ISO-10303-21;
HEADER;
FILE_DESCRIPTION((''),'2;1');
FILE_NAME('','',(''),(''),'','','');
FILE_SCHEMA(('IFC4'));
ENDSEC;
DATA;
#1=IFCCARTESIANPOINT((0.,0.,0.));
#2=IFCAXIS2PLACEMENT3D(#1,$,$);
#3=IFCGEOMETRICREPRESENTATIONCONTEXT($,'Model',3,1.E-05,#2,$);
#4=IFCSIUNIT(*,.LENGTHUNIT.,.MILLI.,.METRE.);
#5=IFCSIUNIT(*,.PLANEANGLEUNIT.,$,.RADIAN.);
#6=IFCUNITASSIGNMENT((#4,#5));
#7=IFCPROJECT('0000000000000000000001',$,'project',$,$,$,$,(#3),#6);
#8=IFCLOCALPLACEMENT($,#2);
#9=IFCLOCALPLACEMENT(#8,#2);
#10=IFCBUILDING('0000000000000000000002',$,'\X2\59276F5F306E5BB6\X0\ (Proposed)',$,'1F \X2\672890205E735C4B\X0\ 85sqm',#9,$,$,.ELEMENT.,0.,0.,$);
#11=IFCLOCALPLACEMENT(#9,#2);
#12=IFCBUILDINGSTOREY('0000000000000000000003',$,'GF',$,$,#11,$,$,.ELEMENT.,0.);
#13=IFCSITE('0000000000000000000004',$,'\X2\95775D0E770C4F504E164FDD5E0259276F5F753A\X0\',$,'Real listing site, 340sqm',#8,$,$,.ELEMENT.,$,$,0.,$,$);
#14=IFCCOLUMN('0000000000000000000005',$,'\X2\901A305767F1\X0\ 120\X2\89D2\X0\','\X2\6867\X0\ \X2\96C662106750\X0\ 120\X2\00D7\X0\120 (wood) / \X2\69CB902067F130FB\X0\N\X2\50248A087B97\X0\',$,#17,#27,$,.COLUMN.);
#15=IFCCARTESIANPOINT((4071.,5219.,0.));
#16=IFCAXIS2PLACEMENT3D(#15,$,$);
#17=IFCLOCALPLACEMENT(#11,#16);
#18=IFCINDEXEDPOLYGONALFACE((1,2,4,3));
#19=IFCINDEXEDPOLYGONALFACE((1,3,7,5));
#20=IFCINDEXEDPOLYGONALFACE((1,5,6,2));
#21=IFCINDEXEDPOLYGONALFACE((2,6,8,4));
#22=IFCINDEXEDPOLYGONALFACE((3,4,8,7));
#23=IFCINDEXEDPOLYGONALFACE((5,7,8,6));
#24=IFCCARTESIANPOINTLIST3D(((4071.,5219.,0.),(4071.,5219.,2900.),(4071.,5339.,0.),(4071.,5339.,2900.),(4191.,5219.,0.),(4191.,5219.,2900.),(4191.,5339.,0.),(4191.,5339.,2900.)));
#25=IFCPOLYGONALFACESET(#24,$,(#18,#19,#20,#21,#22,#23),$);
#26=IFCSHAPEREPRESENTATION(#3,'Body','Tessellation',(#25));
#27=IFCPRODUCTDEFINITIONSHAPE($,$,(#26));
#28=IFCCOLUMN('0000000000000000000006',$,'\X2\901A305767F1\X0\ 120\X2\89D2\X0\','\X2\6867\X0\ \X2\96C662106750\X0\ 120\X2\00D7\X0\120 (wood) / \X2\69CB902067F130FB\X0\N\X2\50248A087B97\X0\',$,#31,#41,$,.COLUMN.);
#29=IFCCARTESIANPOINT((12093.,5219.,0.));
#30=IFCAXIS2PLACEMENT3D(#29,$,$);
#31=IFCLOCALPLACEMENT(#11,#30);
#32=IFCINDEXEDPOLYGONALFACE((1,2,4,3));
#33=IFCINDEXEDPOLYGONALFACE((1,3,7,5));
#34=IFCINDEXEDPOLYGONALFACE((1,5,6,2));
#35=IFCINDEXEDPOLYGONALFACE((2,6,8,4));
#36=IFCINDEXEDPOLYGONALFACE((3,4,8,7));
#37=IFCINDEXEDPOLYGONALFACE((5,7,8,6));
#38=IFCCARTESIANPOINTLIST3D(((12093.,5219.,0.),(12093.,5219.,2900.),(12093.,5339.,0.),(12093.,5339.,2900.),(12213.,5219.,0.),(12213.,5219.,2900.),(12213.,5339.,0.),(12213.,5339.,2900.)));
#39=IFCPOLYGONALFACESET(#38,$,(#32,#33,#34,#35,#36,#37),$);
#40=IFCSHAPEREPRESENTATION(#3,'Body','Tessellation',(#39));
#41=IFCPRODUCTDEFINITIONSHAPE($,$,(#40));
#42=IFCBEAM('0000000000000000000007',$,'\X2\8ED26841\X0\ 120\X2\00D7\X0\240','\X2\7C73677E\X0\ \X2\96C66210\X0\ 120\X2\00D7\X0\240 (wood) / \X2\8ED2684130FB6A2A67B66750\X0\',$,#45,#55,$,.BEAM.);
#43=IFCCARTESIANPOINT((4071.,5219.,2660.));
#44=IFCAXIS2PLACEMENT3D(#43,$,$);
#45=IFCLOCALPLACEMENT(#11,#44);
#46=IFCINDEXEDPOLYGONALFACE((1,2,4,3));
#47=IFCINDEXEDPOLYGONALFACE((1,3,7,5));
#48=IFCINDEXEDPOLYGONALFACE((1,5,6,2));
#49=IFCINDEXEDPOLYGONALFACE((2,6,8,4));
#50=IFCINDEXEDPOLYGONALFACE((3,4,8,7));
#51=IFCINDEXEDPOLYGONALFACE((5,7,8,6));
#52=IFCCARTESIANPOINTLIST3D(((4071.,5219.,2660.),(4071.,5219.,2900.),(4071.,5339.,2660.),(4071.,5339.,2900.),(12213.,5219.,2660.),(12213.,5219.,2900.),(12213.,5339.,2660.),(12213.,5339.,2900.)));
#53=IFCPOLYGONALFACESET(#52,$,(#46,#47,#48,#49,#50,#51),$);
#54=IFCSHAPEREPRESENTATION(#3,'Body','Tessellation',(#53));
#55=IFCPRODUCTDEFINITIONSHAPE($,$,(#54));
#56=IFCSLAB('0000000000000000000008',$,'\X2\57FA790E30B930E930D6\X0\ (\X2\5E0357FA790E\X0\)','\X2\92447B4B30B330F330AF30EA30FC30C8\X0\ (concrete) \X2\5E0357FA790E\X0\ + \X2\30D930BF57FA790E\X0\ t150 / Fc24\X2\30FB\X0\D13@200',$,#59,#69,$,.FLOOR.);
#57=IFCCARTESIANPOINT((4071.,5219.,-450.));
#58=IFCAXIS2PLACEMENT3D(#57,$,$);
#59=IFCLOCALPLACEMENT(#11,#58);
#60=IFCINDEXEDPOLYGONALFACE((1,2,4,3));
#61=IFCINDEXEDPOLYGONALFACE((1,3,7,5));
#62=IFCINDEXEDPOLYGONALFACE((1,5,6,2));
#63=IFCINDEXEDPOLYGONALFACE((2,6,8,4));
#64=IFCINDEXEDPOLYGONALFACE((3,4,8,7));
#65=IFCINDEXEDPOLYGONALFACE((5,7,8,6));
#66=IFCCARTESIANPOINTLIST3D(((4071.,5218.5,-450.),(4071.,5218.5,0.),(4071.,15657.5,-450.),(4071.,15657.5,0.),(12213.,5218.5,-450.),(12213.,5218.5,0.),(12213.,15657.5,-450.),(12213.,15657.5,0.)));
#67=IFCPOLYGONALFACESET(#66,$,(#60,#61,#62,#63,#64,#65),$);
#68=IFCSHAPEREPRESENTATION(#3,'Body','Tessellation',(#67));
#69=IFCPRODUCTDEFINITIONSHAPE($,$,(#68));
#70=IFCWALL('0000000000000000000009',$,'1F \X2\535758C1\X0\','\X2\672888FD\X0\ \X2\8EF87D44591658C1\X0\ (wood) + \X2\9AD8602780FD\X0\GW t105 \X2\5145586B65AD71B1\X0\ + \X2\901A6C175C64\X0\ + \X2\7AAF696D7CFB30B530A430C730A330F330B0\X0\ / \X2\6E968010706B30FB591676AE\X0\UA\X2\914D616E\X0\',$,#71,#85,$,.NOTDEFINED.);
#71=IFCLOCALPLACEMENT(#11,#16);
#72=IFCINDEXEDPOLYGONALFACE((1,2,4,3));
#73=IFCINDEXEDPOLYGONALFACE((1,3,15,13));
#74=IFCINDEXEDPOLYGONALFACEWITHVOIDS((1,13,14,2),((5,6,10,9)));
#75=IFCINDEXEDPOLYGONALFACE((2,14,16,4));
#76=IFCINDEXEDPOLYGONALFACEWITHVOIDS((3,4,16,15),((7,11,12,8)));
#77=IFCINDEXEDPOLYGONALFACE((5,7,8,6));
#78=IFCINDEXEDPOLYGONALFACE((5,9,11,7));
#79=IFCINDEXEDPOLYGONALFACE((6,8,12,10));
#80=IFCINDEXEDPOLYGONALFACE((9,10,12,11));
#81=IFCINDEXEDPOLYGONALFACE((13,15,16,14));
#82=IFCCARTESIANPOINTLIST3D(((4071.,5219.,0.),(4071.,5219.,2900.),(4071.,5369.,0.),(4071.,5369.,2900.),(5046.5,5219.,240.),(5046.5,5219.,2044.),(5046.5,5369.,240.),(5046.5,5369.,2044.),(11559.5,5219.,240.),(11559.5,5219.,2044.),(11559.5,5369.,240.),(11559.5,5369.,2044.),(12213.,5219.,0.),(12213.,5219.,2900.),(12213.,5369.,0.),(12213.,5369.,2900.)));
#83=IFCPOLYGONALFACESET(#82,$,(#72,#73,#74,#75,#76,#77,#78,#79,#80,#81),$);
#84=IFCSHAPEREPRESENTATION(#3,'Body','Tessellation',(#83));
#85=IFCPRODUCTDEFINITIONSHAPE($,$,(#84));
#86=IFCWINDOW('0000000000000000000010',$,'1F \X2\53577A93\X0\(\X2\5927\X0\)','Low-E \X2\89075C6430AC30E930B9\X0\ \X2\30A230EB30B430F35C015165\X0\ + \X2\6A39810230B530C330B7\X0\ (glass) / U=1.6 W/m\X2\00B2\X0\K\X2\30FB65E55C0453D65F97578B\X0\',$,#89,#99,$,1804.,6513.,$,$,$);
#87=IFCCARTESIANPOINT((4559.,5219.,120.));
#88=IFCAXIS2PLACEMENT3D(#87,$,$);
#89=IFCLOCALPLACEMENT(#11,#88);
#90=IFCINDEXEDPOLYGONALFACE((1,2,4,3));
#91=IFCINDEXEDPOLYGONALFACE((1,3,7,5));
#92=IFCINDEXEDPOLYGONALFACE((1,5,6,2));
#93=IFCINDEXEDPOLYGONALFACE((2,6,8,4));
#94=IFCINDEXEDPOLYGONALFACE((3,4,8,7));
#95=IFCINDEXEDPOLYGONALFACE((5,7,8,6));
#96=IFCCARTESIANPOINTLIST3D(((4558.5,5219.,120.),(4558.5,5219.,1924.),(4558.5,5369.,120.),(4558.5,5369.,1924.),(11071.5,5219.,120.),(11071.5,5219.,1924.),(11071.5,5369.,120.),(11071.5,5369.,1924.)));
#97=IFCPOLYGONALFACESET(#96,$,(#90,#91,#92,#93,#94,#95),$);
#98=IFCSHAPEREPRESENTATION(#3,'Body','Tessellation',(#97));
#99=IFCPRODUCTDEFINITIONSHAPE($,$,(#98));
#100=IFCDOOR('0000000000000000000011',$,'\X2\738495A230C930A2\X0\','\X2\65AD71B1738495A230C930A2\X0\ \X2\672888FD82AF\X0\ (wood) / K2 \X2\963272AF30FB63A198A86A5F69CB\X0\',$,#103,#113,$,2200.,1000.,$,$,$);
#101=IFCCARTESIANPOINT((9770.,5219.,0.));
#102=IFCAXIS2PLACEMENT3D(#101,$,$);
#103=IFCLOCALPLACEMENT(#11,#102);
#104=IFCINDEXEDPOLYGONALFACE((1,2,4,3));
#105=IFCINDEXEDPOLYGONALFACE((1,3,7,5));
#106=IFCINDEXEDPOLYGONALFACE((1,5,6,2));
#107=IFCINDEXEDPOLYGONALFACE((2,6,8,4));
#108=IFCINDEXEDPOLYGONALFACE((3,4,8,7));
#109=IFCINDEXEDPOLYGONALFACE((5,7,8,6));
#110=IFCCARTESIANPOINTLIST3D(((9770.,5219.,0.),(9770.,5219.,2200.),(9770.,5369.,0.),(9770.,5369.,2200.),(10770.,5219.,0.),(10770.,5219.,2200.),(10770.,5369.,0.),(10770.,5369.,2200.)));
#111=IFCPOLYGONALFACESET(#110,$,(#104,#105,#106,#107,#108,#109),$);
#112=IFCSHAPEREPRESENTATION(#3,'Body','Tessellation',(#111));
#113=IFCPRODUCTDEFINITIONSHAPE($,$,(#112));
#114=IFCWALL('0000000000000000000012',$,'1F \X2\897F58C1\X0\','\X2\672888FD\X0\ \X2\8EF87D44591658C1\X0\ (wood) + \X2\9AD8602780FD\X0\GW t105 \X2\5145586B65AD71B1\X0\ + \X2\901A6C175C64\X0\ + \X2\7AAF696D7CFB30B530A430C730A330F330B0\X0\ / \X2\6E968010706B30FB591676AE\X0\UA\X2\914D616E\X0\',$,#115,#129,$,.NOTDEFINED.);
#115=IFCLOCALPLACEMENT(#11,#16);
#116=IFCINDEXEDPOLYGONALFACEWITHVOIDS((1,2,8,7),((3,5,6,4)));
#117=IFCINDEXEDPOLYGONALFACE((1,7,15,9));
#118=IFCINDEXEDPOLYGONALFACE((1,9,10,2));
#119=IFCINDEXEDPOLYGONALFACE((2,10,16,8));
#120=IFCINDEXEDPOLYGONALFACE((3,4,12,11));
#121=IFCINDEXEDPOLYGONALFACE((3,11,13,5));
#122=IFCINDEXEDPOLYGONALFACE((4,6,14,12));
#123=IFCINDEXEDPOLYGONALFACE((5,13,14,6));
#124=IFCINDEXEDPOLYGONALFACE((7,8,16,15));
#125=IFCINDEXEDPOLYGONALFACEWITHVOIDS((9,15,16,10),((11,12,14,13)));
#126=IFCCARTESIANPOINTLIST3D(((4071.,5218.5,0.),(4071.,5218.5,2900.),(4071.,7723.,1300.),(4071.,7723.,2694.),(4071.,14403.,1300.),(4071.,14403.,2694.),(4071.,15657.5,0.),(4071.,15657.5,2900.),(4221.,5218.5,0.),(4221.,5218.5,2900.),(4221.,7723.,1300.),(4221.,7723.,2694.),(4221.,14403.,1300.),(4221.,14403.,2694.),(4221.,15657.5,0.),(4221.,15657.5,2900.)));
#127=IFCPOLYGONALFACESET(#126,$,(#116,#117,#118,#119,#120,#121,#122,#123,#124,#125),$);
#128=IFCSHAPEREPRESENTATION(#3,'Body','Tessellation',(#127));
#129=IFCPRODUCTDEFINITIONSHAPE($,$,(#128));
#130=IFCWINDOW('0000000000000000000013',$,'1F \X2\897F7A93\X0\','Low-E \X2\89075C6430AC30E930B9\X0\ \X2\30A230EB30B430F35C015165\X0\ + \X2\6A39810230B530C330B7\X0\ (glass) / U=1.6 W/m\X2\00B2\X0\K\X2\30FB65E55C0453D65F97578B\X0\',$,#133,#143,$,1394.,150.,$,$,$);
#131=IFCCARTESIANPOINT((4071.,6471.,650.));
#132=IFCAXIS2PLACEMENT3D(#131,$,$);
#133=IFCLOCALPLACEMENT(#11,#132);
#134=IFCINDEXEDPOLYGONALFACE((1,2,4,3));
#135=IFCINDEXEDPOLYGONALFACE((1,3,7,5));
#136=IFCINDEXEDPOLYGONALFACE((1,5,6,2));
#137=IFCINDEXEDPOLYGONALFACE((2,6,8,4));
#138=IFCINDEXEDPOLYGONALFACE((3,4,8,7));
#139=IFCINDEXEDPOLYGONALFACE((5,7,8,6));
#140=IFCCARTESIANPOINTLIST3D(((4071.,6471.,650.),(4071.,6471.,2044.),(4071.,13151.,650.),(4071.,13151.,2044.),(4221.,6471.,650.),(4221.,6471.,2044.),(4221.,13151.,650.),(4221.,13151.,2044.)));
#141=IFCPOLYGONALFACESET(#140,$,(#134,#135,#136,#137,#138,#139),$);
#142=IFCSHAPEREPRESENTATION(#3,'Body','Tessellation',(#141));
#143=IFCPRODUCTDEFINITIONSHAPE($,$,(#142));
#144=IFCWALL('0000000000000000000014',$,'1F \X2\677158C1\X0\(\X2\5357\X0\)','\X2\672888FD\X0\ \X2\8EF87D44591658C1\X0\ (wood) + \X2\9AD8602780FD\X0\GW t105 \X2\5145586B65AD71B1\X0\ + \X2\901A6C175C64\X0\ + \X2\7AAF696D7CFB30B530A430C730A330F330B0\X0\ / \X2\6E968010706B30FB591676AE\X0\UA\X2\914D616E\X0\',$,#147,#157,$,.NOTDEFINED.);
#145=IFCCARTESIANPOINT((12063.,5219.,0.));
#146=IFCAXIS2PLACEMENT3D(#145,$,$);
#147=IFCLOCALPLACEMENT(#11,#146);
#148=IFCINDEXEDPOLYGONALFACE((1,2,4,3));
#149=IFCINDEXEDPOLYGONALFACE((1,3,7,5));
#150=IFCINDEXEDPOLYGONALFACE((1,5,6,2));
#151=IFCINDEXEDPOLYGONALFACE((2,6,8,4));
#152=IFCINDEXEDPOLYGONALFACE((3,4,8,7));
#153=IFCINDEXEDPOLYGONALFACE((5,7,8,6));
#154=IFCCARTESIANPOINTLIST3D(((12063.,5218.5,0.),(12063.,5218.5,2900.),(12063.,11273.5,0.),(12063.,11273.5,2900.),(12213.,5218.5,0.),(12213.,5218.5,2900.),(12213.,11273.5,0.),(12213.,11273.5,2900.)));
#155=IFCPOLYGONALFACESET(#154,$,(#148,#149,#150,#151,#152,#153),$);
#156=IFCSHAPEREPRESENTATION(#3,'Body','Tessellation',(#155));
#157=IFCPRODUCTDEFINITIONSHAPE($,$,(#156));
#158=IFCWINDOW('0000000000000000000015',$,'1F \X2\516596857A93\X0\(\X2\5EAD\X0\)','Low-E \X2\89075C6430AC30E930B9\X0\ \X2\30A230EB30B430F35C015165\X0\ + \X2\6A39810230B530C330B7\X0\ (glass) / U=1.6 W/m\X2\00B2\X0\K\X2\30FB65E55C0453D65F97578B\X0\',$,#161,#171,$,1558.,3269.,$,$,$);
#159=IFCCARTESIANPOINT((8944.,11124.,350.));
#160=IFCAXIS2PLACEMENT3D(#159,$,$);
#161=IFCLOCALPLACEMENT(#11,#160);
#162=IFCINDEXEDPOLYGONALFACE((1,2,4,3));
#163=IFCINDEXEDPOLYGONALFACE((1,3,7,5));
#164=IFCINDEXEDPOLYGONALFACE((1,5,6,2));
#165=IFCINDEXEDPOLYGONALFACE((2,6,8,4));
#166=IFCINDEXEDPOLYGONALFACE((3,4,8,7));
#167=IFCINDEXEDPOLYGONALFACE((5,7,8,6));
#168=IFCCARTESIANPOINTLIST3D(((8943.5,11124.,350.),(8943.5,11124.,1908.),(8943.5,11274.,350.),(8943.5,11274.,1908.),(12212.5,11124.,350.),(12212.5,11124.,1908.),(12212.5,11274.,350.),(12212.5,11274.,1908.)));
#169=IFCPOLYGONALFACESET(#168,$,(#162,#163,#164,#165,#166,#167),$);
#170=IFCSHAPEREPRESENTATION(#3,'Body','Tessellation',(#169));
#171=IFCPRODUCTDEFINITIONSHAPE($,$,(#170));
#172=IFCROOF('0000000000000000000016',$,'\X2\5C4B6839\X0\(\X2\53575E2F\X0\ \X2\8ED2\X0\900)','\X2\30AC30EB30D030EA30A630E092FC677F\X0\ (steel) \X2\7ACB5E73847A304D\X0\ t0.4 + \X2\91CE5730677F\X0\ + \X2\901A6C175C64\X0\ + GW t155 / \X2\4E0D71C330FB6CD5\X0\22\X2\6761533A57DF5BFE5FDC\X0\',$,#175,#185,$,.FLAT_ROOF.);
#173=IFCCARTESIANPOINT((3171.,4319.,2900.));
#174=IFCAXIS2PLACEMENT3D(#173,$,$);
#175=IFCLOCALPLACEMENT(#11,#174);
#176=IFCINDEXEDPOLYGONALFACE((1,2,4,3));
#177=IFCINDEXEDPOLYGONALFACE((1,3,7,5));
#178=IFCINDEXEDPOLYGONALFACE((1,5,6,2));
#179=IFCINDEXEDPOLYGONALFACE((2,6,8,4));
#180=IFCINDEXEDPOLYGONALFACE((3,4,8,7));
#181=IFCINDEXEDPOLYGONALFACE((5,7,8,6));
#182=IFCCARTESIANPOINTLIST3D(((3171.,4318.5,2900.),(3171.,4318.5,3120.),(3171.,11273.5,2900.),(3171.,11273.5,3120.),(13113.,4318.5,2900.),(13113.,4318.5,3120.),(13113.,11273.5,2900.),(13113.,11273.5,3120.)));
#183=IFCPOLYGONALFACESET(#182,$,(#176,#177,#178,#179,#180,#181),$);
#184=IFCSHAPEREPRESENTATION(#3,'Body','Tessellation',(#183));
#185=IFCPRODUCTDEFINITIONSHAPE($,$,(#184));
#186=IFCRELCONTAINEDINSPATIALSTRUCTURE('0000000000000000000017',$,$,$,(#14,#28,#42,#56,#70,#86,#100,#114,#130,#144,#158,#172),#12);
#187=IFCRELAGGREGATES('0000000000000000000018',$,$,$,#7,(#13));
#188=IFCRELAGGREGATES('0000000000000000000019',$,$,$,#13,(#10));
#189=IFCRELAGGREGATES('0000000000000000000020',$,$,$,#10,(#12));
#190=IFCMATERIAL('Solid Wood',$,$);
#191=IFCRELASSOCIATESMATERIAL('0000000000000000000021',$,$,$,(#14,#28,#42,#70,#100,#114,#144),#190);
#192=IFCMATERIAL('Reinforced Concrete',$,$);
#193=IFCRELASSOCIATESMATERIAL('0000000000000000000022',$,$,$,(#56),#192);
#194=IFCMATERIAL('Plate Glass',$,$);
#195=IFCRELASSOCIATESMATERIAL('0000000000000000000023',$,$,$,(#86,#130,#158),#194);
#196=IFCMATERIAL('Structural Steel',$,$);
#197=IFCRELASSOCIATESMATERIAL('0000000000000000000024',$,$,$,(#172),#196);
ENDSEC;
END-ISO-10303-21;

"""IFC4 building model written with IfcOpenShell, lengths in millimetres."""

from ifc_helpers import new_model, si_unit, frame, frame_2d, origin, place, context, project, spatial, rectangle, extrude, material, element, fill, save


model = new_model("IFC4")

# Units and contexts
model_context = context("Model", 3, precision=1e-05, world=origin())
ifc_project = project(units=[si_unit("LENGTHUNIT", "METRE", prefix="MILLI"), si_unit("PLANEANGLEUNIT", "RADIAN")], contexts=[model_context])

# Site, building, storey
site_placement = place(None, origin())
site = spatial("IfcSite", under=ifc_project, at=site_placement, Name="長崎県佐世保市大潟町", ObjectType="Real listing site, 340sqm", CompositionType="ELEMENT", RefElevation=0.0)
building_placement = place(site_placement, origin())
building = spatial("IfcBuilding", under=site, at=building_placement, Name="大潟の家 (Proposed)", ObjectType="1F 木造平屋 85sqm", CompositionType="ELEMENT", ElevationOfRefHeight=0.0, ElevationOfTerrain=0.0)
storey_placement = place(building_placement, origin())
storey = spatial("IfcBuildingStorey", under=building, at=storey_placement, Name="GF", CompositionType="ELEMENT", Elevation=0.0)

# Columns
ifc_material_1 = material(Name="Solid Wood")
column_1_placement = place(storey_placement, frame((4071.0, 5219.0, 0.0)))
element("IfcColumn", 1, at=column_1_placement, inside=storey, material=ifc_material_1, Name="通し柱 120角", Description="桧 集成材 120×120 (wood) / 構造柱・N値計算", PredefinedType="COLUMN", context=model_context, shape_type="SweptSolid", body=[
    extrude(rectangle(XDim=120.0, YDim=120.0, at=frame_2d((60.0, 60.0))), frame((4071.0, 5219.0, 0.0)), (0.0, 0.0, 1.0), 2900.0),
])
column_2_placement = place(storey_placement, frame((12093.0, 5219.0, 0.0)))
element("IfcColumn", 2, at=column_2_placement, inside=storey, material=ifc_material_1, Name="通し柱 120角", Description="桧 集成材 120×120 (wood) / 構造柱・N値計算", PredefinedType="COLUMN", context=model_context, shape_type="SweptSolid", body=[
    extrude(rectangle(XDim=120.0, YDim=120.0, at=frame_2d((60.0, 60.0))), frame((12093.0, 5219.0, 0.0)), (0.0, 0.0, 1.0), 2900.0),
])

# Beam
beam_1_placement = place(storey_placement, frame((4071.0, 5219.0, 2660.0)))
element("IfcBeam", 3, at=beam_1_placement, inside=storey, material=ifc_material_1, Name="軒桁 120×240", Description="米松 集成 120×240 (wood) / 軒桁・横架材", PredefinedType="BEAM", context=model_context, shape_type="SweptSolid", body=[
    extrude(rectangle(XDim=8142.0, YDim=120.0, at=frame_2d((4071.0, 60.0))), frame((4071.0, 5219.0, 2660.0)), (0.0, 0.0, 1.0), 240.0),
])

# Slab
ifc_material_2 = material(Name="Reinforced Concrete")
slab_1_placement = place(storey_placement, frame((4071.0, 5219.0, -450.0)))
element("IfcSlab", 4, at=slab_1_placement, inside=storey, material=ifc_material_2, Name="基礎スラブ (布基礎)", Description="鉄筋コンクリート (concrete) 布基礎 + ベタ基礎 t150 / Fc24・D13@200", PredefinedType="FLOOR", context=model_context, shape_type="SweptSolid", body=[
    extrude(rectangle(XDim=8142.0, YDim=10439.0, at=frame_2d((4071.0, 5219.0))), frame((4071.0, 5219.0, -450.0)), (0.0, 0.0, 1.0), 450.0),
])

# Wall, openings, window, door
wall_1_placement = place(storey_placement, frame((4071.0, 5219.0, 0.0)))
wall_1 = element("IfcWall", 5, at=wall_1_placement, inside=storey, material=ifc_material_1, Name="1F 南壁", Description="木製 軸組外壁 (wood) + 高性能GW t105 充填断熱 + 通気層 + 窯業系サイディング / 準耐火・外皮UA配慮", PredefinedType="NOTDEFINED", context=model_context, shape_type="SweptSolid", body=[
    extrude(rectangle(XDim=8142.0, YDim=150.0, at=frame_2d((4071.0, 75.0))), frame((4071.0, 5219.0, 0.0)), (0.0, 0.0, 1.0), 2900.0),
])
opening_1_placement = place(storey_placement, frame((4559.0, 5219.0, 120.0)))
opening_1 = element("IfcOpeningElement", 6, at=opening_1_placement, cuts=wall_1, PredefinedType="NOTDEFINED", context=model_context, shape_type="SweptSolid", body=[
    extrude(rectangle(XDim=6513.0, YDim=150.0, at=frame_2d((3256.0, 75.0))), frame((4559.0, 5219.0, 120.0)), (0.0, 0.0, 1.0), 1804.0),
])
opening_2_placement = place(storey_placement, frame((9770.0, 5219.0, 0.0)))
opening_2 = element("IfcOpeningElement", 7, at=opening_2_placement, cuts=wall_1, PredefinedType="NOTDEFINED", context=model_context, shape_type="SweptSolid", body=[
    extrude(rectangle(XDim=1000.0, YDim=150.0, at=frame_2d((500.0, 75.0))), frame((9770.0, 5219.0, 0.0)), (0.0, 0.0, 1.0), 2200.0),
])
ifc_material_3 = material(Name="Plate Glass")
window_1_placement = place(storey_placement, frame((4559.0, 5219.0, 120.0)))
window_1 = element("IfcWindow", 8, at=window_1_placement, inside=storey, material=ifc_material_3, Name="1F 南窓(大)", Description="Low-E 複層ガラス アルゴン封入 + 樹脂サッシ (glass) / U=1.6 W/m²K・日射取得型", OverallHeight=1804.0, OverallWidth=6513.0, context=model_context, shape_type="SweptSolid", body=[
    extrude(rectangle(XDim=6513.0, YDim=150.0, at=frame_2d((3256.0, 75.0))), frame((4559.0, 5219.0, 120.0)), (0.0, 0.0, 1.0), 1804.0),
])
fill(opening_1, window_1)
door_1_placement = place(storey_placement, frame((9770.0, 5219.0, 0.0)))
door_1 = element("IfcDoor", 9, at=door_1_placement, inside=storey, material=ifc_material_1, Name="玄関ドア", Description="断熱玄関ドア 木製芯 (wood) / K2 防犯・採風機構", OverallHeight=2200.0, OverallWidth=1000.0, context=model_context, shape_type="SweptSolid", body=[
    extrude(rectangle(XDim=1000.0, YDim=150.0, at=frame_2d((500.0, 75.0))), frame((9770.0, 5219.0, 0.0)), (0.0, 0.0, 1.0), 2200.0),
])
fill(opening_2, door_1)

# Walls, openings, windows
wall_2_placement = place(storey_placement, frame((4071.0, 5219.0, 0.0)))
wall_2 = element("IfcWall", 10, at=wall_2_placement, inside=storey, material=ifc_material_1, Name="1F 西壁", Description="木製 軸組外壁 (wood) + 高性能GW t105 充填断熱 + 通気層 + 窯業系サイディング / 準耐火・外皮UA配慮", PredefinedType="NOTDEFINED", context=model_context, shape_type="SweptSolid", body=[
    extrude(rectangle(XDim=150.0, YDim=10439.0, at=frame_2d((75.0, 5219.0))), frame((4071.0, 5219.0, 0.0)), (0.0, 0.0, 1.0), 2900.0),
])
opening_3_placement = place(storey_placement, frame((4071.0, 6471.0, 650.0)))
opening_3 = element("IfcOpeningElement", 11, at=opening_3_placement, cuts=wall_2, PredefinedType="NOTDEFINED", context=model_context, shape_type="SweptSolid", body=[
    extrude(rectangle(XDim=150.0, YDim=6680.0, at=frame_2d((75.0, 3340.0))), frame((4071.0, 6471.0, 650.0)), (0.0, 0.0, 1.0), 1394.0),
])
window_2_placement = place(storey_placement, frame((4071.0, 6471.0, 650.0)))
window_2 = element("IfcWindow", 12, at=window_2_placement, inside=storey, material=ifc_material_3, Name="1F 西窓", Description="Low-E 複層ガラス アルゴン封入 + 樹脂サッシ (glass) / U=1.6 W/m²K・日射取得型", OverallHeight=1394.0, OverallWidth=150.0, context=model_context, shape_type="SweptSolid", body=[
    extrude(rectangle(XDim=150.0, YDim=6680.0, at=frame_2d((75.0, 3340.0))), frame((4071.0, 6471.0, 650.0)), (0.0, 0.0, 1.0), 1394.0),
])
fill(opening_3, window_2)
wall_3_placement = place(storey_placement, frame((12063.0, 5219.0, 0.0)))
wall_3 = element("IfcWall", 13, at=wall_3_placement, inside=storey, material=ifc_material_1, Name="1F 東壁(南)", Description="木製 軸組外壁 (wood) + 高性能GW t105 充填断熱 + 通気層 + 窯業系サイディング / 準耐火・外皮UA配慮", PredefinedType="NOTDEFINED", context=model_context, shape_type="SweptSolid", body=[
    extrude(rectangle(XDim=150.0, YDim=6055.0, at=frame_2d((75.0, 3027.0))), frame((12063.0, 5219.0, 0.0)), (0.0, 0.0, 1.0), 2900.0),
])
opening_4_placement = place(storey_placement, frame((8944.0, 11124.0, 350.0)))
opening_4 = element("IfcOpeningElement", 14, at=opening_4_placement, cuts=wall_3, PredefinedType="NOTDEFINED", context=model_context, shape_type="SweptSolid", body=[
    extrude(rectangle(XDim=3269.0, YDim=150.0, at=frame_2d((1634.0, 75.0))), frame((8944.0, 11124.0, 350.0)), (0.0, 0.0, 1.0), 1558.0),
])
window_3_placement = place(storey_placement, frame((8944.0, 11124.0, 350.0)))
window_3 = element("IfcWindow", 15, at=window_3_placement, inside=storey, material=ifc_material_3, Name="1F 入隅窓(庭)", Description="Low-E 複層ガラス アルゴン封入 + 樹脂サッシ (glass) / U=1.6 W/m²K・日射取得型", OverallHeight=1558.0, OverallWidth=3269.0, context=model_context, shape_type="SweptSolid", body=[
    extrude(rectangle(XDim=3269.0, YDim=150.0, at=frame_2d((1634.0, 75.0))), frame((8944.0, 11124.0, 350.0)), (0.0, 0.0, 1.0), 1558.0),
])
fill(opening_4, window_3)

# Roof
ifc_material_4 = material(Name="Structural Steel")
roof_placement = place(storey_placement, frame((3171.0, 4319.0, 2900.0)))
element("IfcRoof", 16, at=roof_placement, inside=storey, material=ifc_material_4, Name="屋根(南帯 軒900)", Description="ガルバリウム鋼板 (steel) 立平葺き t0.4 + 野地板 + 通気層 + GW t155 / 不燃・法22条区域対応", PredefinedType="FLAT_ROOF", context=model_context, shape_type="SweptSolid", body=[
    extrude(rectangle(XDim=9942.0, YDim=6955.0, at=frame_2d((4971.0, 3477.0))), frame((3171.0, 4319.0, 2900.0)), (0.0, 0.0, 1.0), 220.0),
])

save(model, "model.ifc")
